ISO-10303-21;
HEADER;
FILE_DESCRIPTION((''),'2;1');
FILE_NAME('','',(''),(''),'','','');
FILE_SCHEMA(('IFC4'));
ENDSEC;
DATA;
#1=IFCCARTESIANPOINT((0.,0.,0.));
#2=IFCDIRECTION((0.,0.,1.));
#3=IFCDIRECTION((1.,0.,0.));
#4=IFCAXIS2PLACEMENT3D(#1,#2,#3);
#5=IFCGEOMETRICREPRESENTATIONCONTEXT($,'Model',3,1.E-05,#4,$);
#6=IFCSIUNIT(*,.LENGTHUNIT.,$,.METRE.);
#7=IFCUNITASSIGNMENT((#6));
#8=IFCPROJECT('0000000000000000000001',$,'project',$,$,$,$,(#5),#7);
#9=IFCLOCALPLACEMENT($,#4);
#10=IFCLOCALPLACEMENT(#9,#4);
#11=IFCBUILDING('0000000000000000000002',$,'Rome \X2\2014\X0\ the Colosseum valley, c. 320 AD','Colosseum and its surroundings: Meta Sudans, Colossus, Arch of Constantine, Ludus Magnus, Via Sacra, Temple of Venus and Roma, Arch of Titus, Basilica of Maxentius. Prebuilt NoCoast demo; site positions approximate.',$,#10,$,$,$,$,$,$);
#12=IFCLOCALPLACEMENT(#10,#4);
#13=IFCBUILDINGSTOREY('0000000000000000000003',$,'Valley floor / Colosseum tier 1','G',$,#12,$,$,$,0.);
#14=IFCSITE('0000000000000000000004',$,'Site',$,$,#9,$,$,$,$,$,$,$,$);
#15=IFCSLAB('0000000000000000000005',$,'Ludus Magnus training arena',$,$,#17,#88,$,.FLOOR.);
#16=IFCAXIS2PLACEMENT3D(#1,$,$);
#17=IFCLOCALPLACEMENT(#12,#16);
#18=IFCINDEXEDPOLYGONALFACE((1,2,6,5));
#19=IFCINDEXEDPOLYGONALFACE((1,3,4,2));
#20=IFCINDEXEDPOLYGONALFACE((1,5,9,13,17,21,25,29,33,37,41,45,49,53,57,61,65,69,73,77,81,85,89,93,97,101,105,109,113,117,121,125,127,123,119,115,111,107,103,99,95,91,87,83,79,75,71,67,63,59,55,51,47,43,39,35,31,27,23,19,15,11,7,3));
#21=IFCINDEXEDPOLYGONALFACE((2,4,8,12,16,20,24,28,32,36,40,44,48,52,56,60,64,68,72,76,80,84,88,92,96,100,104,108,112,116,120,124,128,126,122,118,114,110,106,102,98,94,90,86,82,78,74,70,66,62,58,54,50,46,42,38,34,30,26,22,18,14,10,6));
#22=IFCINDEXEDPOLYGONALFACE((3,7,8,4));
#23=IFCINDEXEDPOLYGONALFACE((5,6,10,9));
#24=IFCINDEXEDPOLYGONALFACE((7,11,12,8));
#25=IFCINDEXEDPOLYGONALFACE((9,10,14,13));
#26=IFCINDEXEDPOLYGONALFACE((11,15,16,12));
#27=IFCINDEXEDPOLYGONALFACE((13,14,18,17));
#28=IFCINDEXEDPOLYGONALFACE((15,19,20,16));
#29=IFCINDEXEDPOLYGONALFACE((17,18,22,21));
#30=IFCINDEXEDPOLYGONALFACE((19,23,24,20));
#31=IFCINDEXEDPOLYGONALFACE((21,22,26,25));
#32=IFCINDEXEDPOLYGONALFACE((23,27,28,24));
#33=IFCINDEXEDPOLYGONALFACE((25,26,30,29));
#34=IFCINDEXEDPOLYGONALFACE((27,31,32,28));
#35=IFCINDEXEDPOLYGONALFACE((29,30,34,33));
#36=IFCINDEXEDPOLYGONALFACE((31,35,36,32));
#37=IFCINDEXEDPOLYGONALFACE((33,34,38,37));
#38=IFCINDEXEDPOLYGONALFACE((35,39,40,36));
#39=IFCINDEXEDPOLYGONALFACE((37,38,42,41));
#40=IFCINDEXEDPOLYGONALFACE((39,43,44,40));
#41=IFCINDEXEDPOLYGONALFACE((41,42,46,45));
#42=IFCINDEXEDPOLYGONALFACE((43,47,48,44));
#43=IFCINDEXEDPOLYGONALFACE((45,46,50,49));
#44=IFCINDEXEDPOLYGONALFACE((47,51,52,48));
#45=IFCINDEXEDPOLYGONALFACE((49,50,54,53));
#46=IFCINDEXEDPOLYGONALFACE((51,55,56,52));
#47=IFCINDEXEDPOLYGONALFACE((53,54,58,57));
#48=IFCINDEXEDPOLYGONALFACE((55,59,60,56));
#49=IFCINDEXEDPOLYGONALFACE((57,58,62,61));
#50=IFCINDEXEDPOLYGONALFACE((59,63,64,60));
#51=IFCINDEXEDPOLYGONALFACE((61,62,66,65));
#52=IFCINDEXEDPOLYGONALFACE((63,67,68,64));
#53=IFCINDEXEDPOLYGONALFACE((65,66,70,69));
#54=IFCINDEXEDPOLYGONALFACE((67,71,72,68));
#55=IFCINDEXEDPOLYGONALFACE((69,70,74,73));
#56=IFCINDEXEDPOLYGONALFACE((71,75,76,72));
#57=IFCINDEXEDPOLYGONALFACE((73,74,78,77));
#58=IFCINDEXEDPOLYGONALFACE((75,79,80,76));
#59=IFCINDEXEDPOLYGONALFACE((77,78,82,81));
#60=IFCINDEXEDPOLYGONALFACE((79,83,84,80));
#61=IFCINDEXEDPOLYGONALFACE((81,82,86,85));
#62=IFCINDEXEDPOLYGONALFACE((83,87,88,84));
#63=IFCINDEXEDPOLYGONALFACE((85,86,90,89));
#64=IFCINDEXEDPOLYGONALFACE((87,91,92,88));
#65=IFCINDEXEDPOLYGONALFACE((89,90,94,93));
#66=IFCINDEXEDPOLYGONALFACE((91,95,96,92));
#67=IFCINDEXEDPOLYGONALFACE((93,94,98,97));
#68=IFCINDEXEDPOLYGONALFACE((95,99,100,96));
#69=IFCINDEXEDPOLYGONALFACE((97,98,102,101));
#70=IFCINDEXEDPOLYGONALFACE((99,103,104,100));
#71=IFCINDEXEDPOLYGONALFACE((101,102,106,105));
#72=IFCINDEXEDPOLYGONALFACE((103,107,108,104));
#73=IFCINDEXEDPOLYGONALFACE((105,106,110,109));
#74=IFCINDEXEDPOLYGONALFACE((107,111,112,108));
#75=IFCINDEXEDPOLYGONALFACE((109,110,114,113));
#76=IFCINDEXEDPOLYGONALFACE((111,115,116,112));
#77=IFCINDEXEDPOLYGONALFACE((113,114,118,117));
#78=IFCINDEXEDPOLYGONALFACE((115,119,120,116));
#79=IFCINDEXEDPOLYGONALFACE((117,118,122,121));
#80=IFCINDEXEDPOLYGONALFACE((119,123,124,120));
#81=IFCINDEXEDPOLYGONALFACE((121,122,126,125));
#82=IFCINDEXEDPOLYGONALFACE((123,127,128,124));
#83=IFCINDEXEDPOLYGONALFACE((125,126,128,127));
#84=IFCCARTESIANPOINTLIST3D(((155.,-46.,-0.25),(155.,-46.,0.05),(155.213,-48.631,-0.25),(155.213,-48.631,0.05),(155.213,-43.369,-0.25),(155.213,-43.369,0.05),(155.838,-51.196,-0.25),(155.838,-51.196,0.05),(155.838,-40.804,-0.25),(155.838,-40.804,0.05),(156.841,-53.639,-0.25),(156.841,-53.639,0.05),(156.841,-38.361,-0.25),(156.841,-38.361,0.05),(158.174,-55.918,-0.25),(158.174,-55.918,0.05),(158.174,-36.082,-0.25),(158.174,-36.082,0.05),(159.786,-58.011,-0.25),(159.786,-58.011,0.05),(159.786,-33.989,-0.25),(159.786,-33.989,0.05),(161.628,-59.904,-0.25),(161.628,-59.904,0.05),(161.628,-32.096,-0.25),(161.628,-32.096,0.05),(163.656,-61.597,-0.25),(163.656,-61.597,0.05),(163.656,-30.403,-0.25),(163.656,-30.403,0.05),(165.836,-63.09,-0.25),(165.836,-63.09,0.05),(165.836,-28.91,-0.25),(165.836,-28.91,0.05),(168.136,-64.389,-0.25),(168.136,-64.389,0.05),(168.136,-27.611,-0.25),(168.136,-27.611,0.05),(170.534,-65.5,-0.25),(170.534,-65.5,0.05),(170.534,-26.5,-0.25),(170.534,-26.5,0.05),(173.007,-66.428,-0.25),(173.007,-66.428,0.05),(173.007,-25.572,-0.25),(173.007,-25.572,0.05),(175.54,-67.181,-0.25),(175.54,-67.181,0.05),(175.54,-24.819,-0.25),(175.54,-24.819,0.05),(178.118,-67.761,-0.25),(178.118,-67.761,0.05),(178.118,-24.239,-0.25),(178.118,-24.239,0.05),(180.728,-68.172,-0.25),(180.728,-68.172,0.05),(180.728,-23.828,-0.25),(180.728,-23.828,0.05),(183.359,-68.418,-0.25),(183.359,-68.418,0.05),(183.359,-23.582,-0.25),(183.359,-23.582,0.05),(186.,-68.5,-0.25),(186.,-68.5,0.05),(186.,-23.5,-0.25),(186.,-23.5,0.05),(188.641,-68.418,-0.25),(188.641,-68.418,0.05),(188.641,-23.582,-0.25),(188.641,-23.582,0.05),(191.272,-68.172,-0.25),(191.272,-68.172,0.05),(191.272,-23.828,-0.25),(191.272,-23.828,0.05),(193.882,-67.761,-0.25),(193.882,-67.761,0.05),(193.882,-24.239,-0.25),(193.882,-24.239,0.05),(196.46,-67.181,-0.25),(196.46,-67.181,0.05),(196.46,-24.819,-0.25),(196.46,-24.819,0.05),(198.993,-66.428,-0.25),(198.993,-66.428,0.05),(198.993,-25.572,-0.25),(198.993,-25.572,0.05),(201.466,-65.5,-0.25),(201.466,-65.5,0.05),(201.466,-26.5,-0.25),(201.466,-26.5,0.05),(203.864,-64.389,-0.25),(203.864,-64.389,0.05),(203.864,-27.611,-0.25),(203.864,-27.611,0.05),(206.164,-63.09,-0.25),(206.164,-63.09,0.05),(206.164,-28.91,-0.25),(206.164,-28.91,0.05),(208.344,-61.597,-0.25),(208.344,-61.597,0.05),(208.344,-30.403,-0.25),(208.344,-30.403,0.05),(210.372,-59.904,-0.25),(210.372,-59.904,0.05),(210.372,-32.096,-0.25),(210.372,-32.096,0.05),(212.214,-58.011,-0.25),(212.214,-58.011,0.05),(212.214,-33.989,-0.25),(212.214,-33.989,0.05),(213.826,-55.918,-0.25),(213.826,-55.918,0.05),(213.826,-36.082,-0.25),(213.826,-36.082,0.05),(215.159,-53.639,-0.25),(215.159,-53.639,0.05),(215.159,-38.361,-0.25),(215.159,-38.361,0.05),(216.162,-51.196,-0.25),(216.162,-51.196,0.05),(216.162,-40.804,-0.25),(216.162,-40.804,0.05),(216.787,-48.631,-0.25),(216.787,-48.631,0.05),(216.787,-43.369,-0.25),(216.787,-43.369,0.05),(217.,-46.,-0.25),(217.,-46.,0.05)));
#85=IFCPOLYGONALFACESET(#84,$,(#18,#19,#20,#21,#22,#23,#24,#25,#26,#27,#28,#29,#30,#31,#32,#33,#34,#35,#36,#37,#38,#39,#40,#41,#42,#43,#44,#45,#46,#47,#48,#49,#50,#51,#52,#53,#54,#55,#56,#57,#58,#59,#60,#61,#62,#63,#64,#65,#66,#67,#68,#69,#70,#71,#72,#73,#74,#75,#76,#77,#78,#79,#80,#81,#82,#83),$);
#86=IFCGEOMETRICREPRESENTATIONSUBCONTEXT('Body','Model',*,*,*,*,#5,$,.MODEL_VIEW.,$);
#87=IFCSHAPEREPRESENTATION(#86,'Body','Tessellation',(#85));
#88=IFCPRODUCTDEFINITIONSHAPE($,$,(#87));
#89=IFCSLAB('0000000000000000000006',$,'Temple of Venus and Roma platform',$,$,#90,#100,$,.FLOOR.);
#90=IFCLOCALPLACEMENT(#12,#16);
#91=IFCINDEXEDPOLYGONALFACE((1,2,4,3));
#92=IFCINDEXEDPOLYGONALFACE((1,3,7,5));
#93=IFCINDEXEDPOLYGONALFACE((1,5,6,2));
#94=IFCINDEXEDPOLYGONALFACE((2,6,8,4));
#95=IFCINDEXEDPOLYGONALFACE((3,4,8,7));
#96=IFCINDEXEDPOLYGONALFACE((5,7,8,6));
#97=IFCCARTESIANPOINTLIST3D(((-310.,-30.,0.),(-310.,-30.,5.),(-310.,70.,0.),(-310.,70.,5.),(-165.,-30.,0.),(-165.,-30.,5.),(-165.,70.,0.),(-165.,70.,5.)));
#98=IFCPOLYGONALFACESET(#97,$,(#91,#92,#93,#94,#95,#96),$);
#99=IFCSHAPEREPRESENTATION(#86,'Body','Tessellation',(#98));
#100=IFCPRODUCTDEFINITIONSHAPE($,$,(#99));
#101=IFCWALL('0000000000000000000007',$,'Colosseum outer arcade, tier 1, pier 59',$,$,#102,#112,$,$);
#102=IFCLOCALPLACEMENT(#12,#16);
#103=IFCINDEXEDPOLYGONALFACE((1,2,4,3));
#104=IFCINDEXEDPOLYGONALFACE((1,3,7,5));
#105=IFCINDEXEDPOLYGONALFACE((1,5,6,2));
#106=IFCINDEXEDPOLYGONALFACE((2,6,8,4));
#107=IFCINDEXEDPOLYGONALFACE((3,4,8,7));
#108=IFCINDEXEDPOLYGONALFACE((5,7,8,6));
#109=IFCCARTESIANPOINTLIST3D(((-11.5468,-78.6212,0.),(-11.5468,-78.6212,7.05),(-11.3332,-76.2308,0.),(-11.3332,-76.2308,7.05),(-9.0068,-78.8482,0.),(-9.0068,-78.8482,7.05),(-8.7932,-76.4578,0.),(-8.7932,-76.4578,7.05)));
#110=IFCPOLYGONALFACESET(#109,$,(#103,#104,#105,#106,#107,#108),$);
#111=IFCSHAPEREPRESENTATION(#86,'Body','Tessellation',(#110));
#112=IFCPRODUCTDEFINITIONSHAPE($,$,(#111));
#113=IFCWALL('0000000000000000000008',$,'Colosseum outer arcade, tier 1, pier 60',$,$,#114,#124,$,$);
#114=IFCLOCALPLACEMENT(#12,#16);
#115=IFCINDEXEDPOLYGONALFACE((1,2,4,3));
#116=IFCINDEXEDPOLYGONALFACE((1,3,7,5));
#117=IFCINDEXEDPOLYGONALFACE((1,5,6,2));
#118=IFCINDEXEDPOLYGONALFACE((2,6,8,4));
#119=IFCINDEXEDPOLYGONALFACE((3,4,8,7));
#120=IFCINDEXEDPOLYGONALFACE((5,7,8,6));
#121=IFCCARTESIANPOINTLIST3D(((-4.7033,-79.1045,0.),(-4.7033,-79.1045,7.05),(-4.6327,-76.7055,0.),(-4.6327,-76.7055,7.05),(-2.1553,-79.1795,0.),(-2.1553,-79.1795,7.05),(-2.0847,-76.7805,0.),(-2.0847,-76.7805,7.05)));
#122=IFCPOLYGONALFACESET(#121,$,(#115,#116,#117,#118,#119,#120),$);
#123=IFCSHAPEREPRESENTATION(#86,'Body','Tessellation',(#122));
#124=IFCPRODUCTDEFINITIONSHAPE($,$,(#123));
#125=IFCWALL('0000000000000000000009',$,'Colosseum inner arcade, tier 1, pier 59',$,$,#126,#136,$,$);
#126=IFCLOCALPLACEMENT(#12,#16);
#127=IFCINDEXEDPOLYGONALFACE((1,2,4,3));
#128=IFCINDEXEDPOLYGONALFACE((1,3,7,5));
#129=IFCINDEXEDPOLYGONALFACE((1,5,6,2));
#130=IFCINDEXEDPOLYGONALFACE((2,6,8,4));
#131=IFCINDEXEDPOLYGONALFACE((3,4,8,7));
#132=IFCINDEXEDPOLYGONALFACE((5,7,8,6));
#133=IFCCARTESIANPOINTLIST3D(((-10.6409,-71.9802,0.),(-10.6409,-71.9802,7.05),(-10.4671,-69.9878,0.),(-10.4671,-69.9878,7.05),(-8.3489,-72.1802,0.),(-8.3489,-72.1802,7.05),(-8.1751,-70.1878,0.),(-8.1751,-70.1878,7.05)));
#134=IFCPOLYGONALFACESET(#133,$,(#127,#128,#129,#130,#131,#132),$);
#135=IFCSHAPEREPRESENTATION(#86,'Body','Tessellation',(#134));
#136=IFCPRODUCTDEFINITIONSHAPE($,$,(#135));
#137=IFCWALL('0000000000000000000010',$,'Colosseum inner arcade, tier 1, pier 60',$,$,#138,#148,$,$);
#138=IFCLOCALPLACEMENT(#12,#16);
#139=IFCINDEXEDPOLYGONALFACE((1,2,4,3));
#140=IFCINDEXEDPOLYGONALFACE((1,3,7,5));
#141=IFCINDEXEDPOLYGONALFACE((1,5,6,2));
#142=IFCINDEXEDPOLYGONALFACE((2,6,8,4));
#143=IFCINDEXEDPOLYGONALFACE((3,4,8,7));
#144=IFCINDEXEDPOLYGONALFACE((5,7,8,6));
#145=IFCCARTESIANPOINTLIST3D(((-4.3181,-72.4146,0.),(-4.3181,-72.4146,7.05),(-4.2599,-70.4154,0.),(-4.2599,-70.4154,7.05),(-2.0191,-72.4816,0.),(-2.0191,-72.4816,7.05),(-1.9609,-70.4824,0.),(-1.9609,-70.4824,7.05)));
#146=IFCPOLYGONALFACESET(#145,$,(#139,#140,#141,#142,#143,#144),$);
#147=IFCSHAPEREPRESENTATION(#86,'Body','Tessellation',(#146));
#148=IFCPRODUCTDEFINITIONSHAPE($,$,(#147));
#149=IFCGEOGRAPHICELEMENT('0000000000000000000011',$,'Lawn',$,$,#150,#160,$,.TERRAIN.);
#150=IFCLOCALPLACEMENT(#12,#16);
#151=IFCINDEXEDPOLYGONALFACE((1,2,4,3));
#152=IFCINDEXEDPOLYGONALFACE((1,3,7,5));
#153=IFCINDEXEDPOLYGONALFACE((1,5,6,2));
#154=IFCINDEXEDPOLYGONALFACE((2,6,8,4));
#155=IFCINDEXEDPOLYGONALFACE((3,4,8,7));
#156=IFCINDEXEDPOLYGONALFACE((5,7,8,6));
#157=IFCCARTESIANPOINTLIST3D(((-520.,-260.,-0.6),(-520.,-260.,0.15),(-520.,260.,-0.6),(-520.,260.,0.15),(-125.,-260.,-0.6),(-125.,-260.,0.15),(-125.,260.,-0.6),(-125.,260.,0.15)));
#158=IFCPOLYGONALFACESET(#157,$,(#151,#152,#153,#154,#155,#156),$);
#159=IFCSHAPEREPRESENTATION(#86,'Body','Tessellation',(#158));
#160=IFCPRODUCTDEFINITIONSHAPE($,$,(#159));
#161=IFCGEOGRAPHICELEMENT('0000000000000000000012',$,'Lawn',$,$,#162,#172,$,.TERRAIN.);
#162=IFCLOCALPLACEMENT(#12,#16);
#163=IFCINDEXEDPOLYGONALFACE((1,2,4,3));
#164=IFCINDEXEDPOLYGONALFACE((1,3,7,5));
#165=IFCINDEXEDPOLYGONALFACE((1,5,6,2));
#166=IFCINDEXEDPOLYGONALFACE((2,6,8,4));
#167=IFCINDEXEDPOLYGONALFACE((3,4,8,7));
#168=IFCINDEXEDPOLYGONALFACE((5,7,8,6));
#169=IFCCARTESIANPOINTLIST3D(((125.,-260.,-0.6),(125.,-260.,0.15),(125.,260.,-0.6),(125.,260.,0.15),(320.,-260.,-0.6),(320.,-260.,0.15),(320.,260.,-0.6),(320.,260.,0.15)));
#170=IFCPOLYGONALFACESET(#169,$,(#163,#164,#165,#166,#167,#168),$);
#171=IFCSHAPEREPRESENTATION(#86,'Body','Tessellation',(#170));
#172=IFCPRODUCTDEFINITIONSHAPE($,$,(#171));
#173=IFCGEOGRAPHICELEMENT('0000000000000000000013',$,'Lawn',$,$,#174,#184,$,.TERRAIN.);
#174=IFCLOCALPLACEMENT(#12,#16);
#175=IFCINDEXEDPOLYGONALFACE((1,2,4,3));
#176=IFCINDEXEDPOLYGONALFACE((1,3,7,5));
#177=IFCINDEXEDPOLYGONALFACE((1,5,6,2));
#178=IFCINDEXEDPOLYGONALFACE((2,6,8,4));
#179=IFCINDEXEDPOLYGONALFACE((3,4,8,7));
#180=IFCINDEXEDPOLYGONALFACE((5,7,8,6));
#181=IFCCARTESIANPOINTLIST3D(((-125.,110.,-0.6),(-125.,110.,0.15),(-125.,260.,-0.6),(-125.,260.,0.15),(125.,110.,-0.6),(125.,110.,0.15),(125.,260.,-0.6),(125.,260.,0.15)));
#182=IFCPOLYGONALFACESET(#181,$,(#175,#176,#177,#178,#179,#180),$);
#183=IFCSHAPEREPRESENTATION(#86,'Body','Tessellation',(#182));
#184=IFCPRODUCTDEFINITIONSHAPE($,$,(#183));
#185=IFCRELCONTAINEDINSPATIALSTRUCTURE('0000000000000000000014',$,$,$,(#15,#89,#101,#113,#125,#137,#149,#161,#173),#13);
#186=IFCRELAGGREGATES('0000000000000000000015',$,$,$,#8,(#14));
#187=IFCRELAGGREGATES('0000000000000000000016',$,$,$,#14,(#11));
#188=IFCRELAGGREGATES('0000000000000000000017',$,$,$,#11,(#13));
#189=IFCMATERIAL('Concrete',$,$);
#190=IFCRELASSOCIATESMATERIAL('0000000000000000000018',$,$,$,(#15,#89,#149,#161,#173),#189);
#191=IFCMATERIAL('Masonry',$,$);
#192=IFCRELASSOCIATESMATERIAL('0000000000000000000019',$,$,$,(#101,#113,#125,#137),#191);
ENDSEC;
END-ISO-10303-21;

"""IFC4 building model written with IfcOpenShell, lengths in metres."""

from ifc_helpers import new_model, si_unit, frame, origin_with_axes, place, context, subcontext, project, spatial, indexed_curve, outline, extrude, material, element, save


model = new_model("IFC4")

# Units and contexts
model_context = context("Model", 3, precision=1e-05, world=origin_with_axes())
body_context = subcontext(model_context, "Body", "Model", "MODEL_VIEW")
ifc_project = project(units=[si_unit("LENGTHUNIT", "METRE")], contexts=[model_context])

# Site, building, storey
site_placement = place(None, origin_with_axes())
site = spatial("IfcSite", under=ifc_project, at=site_placement, Name="Site")
building_placement = place(site_placement, origin_with_axes())
building = spatial("IfcBuilding", under=site, at=building_placement, Name="Rome — the Colosseum valley, c. 320 AD", Description="Colosseum and its surroundings: Meta Sudans, Colossus, Arch of Constantine, Ludus Magnus, Via Sacra, Temple of Venus and Roma, Arch of Titus, Basilica of Maxentius. Prebuilt NoCoast demo; site positions approximate.")
storey_placement = place(building_placement, origin_with_axes())
storey = spatial("IfcBuildingStorey", under=building, at=storey_placement, Name="Valley floor / Colosseum tier 1", Description="G", Elevation=0.0)

# Slabs
ifc_material_1 = material(Name="Concrete")
slab_1_placement = place(storey_placement, frame((0.0, 0.0, -0.25), z_axis=(0.0, 0.0, 1.0), x_axis=(1.0, 0.0, 0.0)))
element("IfcSlab", 1, at=slab_1_placement, inside=storey, material=ifc_material_1, Name="Ludus Magnus training arena", PredefinedType="FLOOR", context=body_context, shape_type="SweptSolid", body=[
    extrude(outline(indexed_curve([(217.0, -46.0), (216.787, -43.369), (216.162, -40.804), (215.159, -38.361), (213.826, -36.082), (212.214, -33.989), (210.372, -32.096), (208.344, -30.403), (206.164, -28.91), (203.864, -27.611), (201.466, -26.5), (198.993, -25.572), (196.46, -24.819), (193.882, -24.239), (191.272, -23.828), (188.641, -23.582), (186.0, -23.5), (183.359, -23.582), (180.728, -23.828), (178.118, -24.239), (175.54, -24.819), (173.007, -25.572), (170.534, -26.5), (168.136, -27.611), (165.836, -28.91), (163.656, -30.403), (161.628, -32.096), (159.786, -33.989), (158.174, -36.082), (156.841, -38.361), (155.838, -40.804), (155.213, -43.369), (155.0, -46.0), (155.213, -48.631), (155.838, -51.196), (156.841, -53.639), (158.174, -55.918), (159.786, -58.011), (161.628, -59.904), (163.656, -61.597), (165.836, -63.09), (168.136, -64.389), (170.534, -65.5), (173.007, -66.428), (175.54, -67.181), (178.118, -67.761), (180.728, -68.172), (183.359, -68.418), (186.0, -68.5), (188.641, -68.418), (191.272, -68.172), (193.882, -67.761), (196.46, -67.181), (198.993, -66.428), (201.466, -65.5), (203.864, -64.389), (206.164, -63.09), (208.344, -61.597), (210.372, -59.904), (212.214, -58.011), (213.826, -55.918), (215.159, -53.639), (216.162, -51.196), (216.787, -48.631)])), None, (0.0, 0.0, 1.0), 0.3),
])
slab_2_placement = place(storey_placement, origin_with_axes())
element("IfcSlab", 2, at=slab_2_placement, inside=storey, material=ifc_material_1, Name="Temple of Venus and Roma platform", PredefinedType="FLOOR", context=body_context, shape_type="SweptSolid", body=[
    extrude(outline(indexed_curve([(-310.0, -30.0), (-165.0, -30.0), (-165.0, 70.0), (-310.0, 70.0)])), None, (0.0, 0.0, 1.0), 5.0),
])

# Walls
ifc_material_2 = material(Name="Masonry")
wall_1_placement = place(storey_placement, frame((-11.44, -77.426, 0.0), z_axis=(0.0, 0.0, 1.0), x_axis=(0.99603, -0.089015, 0.0)))
element("IfcWall", 3, at=wall_1_placement, inside=storey, material=ifc_material_2, Name="Colosseum outer arcade, tier 1, pier 59", context=body_context, shape_type="SweptSolid", body=[
    extrude(outline(indexed_curve([(0.0, 0.0), (0.0, 2.4), (2.5501, 2.4), (2.5501, 0.0), (0.0, 0.0)], self_intersect=False)), frame((0.0, -1.2, 0.0), z_axis=(0.0, 0.0, 1.0), x_axis=(1.0, 0.0, 0.0)), (0.0, 0.0, 1.0), 7.05),
])
wall_2_placement = place(storey_placement, frame((-4.668, -77.905, 0.0), z_axis=(0.0, 0.0, 1.0), x_axis=(0.999567, -0.029422, 0.0)))
element("IfcWall", 4, at=wall_2_placement, inside=storey, material=ifc_material_2, Name="Colosseum outer arcade, tier 1, pier 60", context=body_context, shape_type="SweptSolid", body=[
    extrude(outline(indexed_curve([(0.0, 0.0), (0.0, 2.4), (2.5491, 2.4), (2.5491, 0.0), (0.0, 0.0)], self_intersect=False)), frame((0.0, -1.2, 0.0), z_axis=(0.0, 0.0, 1.0), x_axis=(1.0, 0.0, 0.0)), (0.0, 0.0, 1.0), 7.05),
])
wall_3_placement = place(storey_placement, frame((-10.554, -70.984, 0.0), z_axis=(0.0, 0.0, 1.0), x_axis=(0.996214, -0.08693, 0.0)))
element("IfcWall", 5, at=wall_3_placement, inside=storey, material=ifc_material_2, Name="Colosseum inner arcade, tier 1, pier 59", context=body_context, shape_type="SweptSolid", body=[
    extrude(outline(indexed_curve([(0.0, 0.0), (0.0, 2.0), (2.3007, 2.0), (2.3007, 0.0), (0.0, 0.0)], self_intersect=False)), frame((0.0, -1.0, 0.0), z_axis=(0.0, 0.0, 1.0), x_axis=(1.0, 0.0, 0.0)), (0.0, 0.0, 1.0), 7.05),
])
wall_4_placement = place(storey_placement, frame((-4.289, -71.415, 0.0), z_axis=(0.0, 0.0, 1.0), x_axis=(0.999576, -0.029131, 0.0)))
element("IfcWall", 6, at=wall_4_placement, inside=storey, material=ifc_material_2, Name="Colosseum inner arcade, tier 1, pier 60", context=body_context, shape_type="SweptSolid", body=[
    extrude(outline(indexed_curve([(0.0, 0.0), (0.0, 2.0), (2.3, 2.0), (2.3, 0.0), (0.0, 0.0)], self_intersect=False)), frame((0.0, -1.0, 0.0), z_axis=(0.0, 0.0, 1.0), x_axis=(1.0, 0.0, 0.0)), (0.0, 0.0, 1.0), 7.05),
])

# Geographic elements
geographic_element_1_placement = place(storey_placement, frame((0.0, 0.0, -0.6), z_axis=(0.0, 0.0, 1.0), x_axis=(1.0, 0.0, 0.0)))
element("IfcGeographicElement", 7, at=geographic_element_1_placement, inside=storey, material=ifc_material_1, Name="Lawn", PredefinedType="TERRAIN", context=body_context, shape_type="SweptSolid", body=[
    extrude(outline(indexed_curve([(-520.0, -260.0), (-125.0, -260.0), (-125.0, 260.0), (-520.0, 260.0)])), None, (0.0, 0.0, 1.0), 0.75),
])
geographic_element_2_placement = place(storey_placement, frame((0.0, 0.0, -0.6), z_axis=(0.0, 0.0, 1.0), x_axis=(1.0, 0.0, 0.0)))
element("IfcGeographicElement", 8, at=geographic_element_2_placement, inside=storey, material=ifc_material_1, Name="Lawn", PredefinedType="TERRAIN", context=body_context, shape_type="SweptSolid", body=[
    extrude(outline(indexed_curve([(125.0, -260.0), (320.0, -260.0), (320.0, 260.0), (125.0, 260.0)])), None, (0.0, 0.0, 1.0), 0.75),
])
geographic_element_3_placement = place(storey_placement, frame((0.0, 0.0, -0.6), z_axis=(0.0, 0.0, 1.0), x_axis=(1.0, 0.0, 0.0)))
element("IfcGeographicElement", 9, at=geographic_element_3_placement, inside=storey, material=ifc_material_1, Name="Lawn", PredefinedType="TERRAIN", context=body_context, shape_type="SweptSolid", body=[
    extrude(outline(indexed_curve([(-125.0, 110.0), (125.0, 110.0), (125.0, 260.0), (-125.0, 260.0)])), None, (0.0, 0.0, 1.0), 0.75),
])

save(model, "model.ifc")
